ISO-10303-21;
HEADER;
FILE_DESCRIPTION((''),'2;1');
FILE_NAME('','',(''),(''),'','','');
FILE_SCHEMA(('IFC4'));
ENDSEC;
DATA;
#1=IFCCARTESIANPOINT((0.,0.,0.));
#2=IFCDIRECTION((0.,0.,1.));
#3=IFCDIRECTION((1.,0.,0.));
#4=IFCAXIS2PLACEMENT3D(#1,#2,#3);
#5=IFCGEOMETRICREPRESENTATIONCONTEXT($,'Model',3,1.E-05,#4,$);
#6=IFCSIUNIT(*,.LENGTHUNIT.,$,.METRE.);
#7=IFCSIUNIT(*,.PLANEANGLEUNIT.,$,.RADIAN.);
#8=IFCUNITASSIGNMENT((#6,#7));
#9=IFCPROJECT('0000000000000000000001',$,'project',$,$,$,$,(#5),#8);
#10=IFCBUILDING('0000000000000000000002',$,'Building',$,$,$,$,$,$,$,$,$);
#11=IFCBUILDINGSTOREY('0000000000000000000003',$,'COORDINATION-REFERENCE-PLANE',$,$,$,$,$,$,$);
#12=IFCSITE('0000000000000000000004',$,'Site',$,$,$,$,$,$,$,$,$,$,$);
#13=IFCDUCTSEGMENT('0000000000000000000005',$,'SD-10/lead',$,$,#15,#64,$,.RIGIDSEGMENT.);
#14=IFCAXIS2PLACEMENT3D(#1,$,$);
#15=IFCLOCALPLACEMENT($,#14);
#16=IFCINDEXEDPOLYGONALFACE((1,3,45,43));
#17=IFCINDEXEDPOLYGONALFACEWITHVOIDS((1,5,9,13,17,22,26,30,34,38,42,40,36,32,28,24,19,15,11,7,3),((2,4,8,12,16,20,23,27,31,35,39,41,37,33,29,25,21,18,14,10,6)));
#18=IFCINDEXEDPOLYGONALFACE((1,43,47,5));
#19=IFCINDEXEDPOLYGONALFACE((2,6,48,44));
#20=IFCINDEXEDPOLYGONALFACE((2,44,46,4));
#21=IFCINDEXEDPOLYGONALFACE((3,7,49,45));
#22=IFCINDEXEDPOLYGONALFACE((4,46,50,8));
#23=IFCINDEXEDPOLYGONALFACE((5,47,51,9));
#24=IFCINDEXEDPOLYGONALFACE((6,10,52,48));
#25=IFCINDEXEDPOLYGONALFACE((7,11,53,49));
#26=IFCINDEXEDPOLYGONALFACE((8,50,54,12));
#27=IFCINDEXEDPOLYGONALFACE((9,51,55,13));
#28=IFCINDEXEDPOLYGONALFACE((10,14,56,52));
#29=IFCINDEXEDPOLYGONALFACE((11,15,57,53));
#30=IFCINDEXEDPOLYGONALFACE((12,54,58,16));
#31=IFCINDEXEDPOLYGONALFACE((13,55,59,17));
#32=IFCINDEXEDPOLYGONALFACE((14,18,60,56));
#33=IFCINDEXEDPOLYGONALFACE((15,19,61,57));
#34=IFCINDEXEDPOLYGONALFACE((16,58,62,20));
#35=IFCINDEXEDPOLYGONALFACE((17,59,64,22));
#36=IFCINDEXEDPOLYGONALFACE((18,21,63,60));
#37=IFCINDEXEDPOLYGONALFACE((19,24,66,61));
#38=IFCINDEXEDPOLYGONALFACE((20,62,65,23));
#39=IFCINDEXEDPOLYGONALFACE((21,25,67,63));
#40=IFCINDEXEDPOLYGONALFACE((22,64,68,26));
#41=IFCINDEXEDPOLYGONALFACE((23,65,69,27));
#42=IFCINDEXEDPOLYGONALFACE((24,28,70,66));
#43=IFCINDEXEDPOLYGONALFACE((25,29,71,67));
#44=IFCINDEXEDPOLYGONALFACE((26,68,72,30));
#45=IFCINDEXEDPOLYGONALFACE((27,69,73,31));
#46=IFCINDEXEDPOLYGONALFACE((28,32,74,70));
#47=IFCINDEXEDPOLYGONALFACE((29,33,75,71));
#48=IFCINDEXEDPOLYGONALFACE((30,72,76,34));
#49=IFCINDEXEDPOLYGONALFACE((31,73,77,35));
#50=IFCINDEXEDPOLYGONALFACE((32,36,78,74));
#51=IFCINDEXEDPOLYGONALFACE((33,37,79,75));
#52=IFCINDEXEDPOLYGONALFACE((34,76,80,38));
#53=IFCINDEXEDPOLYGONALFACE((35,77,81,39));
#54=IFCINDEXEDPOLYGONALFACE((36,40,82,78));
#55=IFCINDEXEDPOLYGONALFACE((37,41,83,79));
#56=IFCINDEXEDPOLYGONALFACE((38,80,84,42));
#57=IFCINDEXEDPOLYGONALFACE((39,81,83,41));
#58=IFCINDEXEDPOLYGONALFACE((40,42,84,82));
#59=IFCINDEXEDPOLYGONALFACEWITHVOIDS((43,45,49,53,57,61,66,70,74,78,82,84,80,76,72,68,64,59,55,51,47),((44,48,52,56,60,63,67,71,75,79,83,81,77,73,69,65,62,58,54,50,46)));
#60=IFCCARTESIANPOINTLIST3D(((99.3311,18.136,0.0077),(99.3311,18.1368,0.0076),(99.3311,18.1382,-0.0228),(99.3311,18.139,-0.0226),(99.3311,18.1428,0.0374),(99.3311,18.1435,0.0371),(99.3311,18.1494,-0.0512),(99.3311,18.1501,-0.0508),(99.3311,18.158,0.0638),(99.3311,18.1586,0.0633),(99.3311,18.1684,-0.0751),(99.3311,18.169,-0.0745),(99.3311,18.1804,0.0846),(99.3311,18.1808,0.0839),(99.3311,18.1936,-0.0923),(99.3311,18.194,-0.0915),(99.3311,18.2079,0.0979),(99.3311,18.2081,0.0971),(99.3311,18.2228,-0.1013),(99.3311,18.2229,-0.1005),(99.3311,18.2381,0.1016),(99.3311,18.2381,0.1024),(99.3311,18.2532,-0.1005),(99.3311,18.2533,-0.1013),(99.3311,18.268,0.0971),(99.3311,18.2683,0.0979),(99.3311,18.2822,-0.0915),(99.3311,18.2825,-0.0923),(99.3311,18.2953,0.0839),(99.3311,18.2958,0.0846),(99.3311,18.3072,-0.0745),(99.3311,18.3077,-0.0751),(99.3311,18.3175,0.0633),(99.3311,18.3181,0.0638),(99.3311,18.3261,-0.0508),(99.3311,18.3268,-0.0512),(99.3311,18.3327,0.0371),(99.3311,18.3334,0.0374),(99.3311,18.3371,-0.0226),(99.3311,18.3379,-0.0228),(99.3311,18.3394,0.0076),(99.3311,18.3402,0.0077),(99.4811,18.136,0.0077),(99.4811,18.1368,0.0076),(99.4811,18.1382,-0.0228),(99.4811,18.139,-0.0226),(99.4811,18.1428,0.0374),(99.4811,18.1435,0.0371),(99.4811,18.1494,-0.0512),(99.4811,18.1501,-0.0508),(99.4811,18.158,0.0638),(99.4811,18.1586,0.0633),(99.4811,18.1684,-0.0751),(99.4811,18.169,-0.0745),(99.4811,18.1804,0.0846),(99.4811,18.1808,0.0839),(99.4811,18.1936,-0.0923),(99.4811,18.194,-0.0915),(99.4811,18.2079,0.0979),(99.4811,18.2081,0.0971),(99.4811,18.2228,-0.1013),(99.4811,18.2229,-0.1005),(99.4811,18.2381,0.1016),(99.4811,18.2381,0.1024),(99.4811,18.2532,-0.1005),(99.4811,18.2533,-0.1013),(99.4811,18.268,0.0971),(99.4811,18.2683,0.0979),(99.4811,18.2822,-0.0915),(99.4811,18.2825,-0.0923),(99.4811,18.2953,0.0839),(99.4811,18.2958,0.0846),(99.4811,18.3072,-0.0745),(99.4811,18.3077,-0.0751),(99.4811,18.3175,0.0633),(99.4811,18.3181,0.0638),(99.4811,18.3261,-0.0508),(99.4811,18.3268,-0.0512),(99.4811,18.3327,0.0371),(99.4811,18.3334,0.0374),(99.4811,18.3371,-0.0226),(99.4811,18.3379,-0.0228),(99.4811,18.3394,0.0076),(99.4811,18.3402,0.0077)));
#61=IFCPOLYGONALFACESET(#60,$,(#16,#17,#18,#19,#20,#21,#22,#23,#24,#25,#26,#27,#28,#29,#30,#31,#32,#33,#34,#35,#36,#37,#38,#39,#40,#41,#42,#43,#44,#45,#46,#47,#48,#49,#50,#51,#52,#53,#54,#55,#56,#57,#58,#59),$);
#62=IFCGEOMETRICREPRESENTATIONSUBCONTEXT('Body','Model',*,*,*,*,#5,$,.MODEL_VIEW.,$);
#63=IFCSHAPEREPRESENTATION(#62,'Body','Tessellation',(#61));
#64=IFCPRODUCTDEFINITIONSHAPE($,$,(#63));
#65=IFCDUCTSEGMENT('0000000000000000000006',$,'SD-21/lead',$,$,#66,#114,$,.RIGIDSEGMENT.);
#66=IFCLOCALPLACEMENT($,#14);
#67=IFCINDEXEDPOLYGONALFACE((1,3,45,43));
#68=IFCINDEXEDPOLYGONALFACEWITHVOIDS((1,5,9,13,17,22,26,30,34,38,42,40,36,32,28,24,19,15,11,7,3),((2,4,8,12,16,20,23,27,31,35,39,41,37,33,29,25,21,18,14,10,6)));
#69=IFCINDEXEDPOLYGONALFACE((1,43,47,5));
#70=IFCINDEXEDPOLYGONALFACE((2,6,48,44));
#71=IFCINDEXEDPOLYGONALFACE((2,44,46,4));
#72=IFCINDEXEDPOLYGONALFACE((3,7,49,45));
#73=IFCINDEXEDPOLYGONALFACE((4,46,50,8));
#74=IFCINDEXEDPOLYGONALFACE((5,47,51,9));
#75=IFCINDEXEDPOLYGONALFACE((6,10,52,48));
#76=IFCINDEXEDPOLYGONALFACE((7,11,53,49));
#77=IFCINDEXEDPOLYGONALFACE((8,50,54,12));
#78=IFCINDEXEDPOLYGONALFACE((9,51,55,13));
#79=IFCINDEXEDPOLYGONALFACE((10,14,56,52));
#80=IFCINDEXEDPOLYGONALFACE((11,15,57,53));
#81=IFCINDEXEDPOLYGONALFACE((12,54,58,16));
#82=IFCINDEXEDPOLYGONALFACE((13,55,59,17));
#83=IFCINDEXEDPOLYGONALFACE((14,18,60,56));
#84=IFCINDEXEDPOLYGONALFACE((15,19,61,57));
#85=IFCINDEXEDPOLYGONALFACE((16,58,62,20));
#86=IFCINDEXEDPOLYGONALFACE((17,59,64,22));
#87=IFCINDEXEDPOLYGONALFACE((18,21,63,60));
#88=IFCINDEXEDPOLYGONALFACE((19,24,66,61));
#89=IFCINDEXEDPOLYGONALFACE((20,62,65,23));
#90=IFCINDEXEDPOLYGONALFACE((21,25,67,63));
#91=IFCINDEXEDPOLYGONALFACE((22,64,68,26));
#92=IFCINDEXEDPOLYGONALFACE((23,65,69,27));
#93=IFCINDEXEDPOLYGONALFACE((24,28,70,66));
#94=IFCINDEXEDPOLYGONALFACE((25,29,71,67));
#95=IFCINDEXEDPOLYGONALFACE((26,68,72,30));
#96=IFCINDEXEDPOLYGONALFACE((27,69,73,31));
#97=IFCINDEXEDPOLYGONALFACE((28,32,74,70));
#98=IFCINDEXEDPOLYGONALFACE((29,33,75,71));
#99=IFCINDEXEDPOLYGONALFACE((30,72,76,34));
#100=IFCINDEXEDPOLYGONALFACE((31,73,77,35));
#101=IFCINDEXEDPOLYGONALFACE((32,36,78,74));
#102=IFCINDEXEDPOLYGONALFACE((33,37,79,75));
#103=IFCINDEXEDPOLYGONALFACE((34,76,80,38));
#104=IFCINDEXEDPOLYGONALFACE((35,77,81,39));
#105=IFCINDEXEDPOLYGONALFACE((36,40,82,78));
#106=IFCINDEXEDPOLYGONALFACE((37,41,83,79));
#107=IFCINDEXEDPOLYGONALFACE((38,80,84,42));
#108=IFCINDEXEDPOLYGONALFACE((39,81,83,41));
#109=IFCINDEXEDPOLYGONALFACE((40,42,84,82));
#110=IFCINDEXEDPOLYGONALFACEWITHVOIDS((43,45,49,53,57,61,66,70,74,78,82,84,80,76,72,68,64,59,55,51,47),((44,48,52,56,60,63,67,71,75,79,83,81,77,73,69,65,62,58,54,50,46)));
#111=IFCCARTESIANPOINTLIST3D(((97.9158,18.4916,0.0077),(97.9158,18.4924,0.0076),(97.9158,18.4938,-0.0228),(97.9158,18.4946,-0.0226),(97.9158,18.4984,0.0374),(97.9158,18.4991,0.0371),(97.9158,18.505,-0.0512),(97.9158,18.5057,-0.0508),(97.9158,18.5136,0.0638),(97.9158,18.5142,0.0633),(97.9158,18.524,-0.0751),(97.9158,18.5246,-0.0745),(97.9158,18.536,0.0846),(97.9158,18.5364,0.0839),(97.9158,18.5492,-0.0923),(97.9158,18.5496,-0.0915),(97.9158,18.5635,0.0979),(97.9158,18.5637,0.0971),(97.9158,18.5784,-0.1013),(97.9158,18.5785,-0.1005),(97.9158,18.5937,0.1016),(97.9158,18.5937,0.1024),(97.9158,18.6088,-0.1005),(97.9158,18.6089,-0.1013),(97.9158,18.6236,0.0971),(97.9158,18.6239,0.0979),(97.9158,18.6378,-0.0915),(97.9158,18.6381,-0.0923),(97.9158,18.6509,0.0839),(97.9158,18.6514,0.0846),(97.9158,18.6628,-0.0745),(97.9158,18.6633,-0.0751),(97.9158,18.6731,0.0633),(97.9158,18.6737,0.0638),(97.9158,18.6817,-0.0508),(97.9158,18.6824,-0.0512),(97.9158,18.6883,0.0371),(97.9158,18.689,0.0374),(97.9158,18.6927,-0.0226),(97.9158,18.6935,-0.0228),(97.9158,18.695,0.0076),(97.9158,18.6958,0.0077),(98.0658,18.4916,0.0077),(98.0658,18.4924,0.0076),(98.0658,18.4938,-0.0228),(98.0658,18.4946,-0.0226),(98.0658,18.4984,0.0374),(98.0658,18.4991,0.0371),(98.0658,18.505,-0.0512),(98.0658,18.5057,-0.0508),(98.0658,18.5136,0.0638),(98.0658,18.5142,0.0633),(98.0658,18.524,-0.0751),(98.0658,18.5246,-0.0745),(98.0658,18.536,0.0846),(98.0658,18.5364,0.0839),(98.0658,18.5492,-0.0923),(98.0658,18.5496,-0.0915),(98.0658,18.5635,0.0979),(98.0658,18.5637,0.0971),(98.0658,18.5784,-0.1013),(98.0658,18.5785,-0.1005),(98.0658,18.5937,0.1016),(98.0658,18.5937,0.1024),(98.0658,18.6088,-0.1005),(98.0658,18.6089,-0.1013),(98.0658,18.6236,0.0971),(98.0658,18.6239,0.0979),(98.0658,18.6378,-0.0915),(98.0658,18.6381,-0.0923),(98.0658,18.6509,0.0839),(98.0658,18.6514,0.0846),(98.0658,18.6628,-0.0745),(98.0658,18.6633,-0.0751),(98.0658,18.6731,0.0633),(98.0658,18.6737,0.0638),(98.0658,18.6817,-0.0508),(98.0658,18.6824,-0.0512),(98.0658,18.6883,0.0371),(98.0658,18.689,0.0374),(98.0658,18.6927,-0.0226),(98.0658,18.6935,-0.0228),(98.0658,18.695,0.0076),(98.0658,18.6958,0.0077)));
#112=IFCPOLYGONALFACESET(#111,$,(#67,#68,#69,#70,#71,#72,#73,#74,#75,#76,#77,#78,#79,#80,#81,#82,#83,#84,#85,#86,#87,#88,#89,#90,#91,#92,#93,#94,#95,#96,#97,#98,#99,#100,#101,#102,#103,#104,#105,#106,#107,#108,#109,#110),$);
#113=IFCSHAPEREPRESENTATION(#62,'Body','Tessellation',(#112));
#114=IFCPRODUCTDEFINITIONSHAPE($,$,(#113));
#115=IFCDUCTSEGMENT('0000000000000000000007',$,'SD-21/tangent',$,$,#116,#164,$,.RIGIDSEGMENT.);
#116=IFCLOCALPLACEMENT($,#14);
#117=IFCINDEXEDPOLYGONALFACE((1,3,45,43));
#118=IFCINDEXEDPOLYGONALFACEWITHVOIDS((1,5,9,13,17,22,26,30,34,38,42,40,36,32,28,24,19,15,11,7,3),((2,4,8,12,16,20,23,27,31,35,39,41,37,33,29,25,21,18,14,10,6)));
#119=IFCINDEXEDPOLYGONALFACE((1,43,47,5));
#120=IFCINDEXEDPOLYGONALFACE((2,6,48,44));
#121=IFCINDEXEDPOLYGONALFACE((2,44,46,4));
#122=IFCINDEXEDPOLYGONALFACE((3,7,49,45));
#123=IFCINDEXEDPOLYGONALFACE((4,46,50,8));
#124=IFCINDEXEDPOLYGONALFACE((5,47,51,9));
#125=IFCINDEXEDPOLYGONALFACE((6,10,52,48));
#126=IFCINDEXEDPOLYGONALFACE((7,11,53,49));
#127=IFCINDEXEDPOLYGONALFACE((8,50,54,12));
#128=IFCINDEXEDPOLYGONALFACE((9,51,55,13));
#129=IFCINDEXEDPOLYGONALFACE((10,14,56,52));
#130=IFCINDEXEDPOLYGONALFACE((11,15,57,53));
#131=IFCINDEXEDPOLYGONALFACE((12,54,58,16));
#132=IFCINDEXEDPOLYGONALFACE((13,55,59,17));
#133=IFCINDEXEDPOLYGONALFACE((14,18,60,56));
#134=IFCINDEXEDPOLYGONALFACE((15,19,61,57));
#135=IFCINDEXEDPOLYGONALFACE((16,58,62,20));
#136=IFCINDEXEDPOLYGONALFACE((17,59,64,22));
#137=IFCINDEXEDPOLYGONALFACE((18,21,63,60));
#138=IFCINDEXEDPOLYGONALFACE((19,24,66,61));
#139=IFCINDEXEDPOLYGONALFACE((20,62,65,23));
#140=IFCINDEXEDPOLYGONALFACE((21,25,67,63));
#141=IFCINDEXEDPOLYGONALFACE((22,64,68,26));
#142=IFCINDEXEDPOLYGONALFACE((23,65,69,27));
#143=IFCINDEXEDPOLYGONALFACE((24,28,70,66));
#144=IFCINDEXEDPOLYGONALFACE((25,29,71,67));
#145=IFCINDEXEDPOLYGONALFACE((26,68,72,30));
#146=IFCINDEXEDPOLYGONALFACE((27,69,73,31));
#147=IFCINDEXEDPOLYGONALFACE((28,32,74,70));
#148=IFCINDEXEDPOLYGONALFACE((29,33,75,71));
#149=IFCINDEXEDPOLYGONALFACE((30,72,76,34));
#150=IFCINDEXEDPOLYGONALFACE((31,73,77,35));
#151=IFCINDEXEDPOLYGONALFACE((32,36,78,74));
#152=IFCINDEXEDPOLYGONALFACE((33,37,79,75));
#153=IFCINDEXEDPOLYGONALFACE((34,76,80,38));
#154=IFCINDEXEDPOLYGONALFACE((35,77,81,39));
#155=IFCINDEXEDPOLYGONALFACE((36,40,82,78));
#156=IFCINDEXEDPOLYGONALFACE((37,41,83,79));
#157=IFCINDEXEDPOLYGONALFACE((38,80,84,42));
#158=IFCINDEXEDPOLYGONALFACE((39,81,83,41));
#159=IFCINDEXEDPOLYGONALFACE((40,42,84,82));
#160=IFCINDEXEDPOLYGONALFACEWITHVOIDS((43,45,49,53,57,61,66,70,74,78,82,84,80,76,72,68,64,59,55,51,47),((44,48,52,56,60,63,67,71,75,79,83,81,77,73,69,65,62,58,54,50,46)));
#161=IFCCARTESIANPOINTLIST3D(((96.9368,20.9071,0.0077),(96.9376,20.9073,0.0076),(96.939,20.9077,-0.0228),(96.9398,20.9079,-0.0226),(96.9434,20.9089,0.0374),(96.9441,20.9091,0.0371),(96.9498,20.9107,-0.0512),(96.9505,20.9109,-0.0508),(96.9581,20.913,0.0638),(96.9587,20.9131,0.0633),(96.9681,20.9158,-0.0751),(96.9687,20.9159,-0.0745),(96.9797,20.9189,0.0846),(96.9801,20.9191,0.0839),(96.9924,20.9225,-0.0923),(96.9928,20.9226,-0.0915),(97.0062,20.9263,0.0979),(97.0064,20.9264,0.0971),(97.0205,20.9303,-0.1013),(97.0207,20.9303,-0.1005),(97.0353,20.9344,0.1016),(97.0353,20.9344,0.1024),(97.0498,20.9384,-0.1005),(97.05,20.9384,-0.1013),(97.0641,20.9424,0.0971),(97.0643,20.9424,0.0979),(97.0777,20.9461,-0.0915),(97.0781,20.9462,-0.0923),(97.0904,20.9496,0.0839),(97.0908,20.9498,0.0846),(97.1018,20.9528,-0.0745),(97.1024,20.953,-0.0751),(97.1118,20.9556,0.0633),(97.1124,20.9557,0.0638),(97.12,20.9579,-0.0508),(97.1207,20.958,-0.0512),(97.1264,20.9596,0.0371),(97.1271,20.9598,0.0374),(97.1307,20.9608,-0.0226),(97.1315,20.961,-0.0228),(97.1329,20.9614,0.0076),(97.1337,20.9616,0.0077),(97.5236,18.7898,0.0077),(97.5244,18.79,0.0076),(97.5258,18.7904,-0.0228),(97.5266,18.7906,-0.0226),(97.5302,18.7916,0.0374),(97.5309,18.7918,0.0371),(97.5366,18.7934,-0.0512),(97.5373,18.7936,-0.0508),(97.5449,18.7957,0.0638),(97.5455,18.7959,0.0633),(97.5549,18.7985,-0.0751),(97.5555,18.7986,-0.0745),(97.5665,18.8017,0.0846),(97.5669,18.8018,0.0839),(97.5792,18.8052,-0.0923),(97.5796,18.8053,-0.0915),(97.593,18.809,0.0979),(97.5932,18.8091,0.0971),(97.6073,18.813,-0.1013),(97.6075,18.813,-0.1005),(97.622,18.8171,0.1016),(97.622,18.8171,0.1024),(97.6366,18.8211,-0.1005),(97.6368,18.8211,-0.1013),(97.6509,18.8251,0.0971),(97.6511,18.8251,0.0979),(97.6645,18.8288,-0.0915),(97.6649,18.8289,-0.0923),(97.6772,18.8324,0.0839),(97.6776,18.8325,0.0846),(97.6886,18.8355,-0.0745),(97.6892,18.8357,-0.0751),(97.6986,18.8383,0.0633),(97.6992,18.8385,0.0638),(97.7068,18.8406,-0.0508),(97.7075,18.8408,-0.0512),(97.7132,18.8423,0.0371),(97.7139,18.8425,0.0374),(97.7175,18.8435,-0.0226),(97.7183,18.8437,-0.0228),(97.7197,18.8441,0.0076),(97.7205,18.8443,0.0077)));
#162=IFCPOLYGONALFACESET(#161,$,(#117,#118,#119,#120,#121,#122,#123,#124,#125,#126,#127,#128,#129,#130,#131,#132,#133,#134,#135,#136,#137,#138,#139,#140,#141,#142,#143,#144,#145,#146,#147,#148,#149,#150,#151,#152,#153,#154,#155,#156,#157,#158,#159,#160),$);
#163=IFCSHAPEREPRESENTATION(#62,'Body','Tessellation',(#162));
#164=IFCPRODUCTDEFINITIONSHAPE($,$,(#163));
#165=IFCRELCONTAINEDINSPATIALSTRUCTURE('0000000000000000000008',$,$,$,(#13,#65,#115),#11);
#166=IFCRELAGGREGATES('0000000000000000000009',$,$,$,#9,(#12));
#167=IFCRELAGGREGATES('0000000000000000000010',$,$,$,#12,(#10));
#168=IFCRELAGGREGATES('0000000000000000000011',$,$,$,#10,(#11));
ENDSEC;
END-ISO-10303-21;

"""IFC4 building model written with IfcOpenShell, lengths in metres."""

from ifc_helpers import new_model, si_unit, frame, origin_with_axes, place, context, subcontext, project, spatial, hollow_circle, extrude, element, save


model = new_model("IFC4")

# Units and contexts
model_context = context("Model", 3, precision=1e-05, world=origin_with_axes())
body_context_1 = subcontext(model_context, "Body", "Model", "MODEL_VIEW")
ifc_project = project(units=[si_unit("LENGTHUNIT", "METRE"), si_unit("PLANEANGLEUNIT", "RADIAN")], contexts=[model_context])

# Site, building, storey
site = spatial("IfcSite", under=ifc_project, Name="Site")
building = spatial("IfcBuilding", under=site, Name="Building")
storey = spatial("IfcBuildingStorey", under=building, Name="COORDINATION-REFERENCE-PLANE")

# Duct segments
for number, where, z_axis, x_axis, name in (
    (1, (99.3311, 18.2381, 0.0), (1.0, 0.0, 0.0), (0.0, 0.0, 1.0), "SD-10/lead"),
    (2, (98.0658, 18.5937, 0.0), (-1.0, 0.0, 0.0), (0.0, 0.0, 1.0), "SD-21/lead"),
):
    element("IfcDuctSegment", number, at=place(None, frame(where, z_axis=z_axis, x_axis=x_axis)), inside=storey, Name=name, PredefinedType="RIGIDSEGMENT", context=body_context_1, shape_type="SweptSolid", body=[
        extrude(hollow_circle(Radius=0.1024, WallThickness=0.0008), origin_with_axes(), (0.0, 0.0, 1.0), 0.15),
    ])

# Duct segment
duct_segment_1_placement = place(None, frame((97.622, 18.8171, 0.0), z_axis=(-0.267077, 0.963675, 0.0), x_axis=(0.0, 0.0, 1.0)))
element("IfcDuctSegment", 3, at=duct_segment_1_placement, inside=storey, Name="SD-21/tangent", PredefinedType="RIGIDSEGMENT", context=body_context_1, shape_type="SweptSolid", body=[
    extrude(hollow_circle(Radius=0.1024, WallThickness=0.0008), origin_with_axes(), (0.0, 0.0, 1.0), 2.1971),
])

save(model, "model.ifc")
